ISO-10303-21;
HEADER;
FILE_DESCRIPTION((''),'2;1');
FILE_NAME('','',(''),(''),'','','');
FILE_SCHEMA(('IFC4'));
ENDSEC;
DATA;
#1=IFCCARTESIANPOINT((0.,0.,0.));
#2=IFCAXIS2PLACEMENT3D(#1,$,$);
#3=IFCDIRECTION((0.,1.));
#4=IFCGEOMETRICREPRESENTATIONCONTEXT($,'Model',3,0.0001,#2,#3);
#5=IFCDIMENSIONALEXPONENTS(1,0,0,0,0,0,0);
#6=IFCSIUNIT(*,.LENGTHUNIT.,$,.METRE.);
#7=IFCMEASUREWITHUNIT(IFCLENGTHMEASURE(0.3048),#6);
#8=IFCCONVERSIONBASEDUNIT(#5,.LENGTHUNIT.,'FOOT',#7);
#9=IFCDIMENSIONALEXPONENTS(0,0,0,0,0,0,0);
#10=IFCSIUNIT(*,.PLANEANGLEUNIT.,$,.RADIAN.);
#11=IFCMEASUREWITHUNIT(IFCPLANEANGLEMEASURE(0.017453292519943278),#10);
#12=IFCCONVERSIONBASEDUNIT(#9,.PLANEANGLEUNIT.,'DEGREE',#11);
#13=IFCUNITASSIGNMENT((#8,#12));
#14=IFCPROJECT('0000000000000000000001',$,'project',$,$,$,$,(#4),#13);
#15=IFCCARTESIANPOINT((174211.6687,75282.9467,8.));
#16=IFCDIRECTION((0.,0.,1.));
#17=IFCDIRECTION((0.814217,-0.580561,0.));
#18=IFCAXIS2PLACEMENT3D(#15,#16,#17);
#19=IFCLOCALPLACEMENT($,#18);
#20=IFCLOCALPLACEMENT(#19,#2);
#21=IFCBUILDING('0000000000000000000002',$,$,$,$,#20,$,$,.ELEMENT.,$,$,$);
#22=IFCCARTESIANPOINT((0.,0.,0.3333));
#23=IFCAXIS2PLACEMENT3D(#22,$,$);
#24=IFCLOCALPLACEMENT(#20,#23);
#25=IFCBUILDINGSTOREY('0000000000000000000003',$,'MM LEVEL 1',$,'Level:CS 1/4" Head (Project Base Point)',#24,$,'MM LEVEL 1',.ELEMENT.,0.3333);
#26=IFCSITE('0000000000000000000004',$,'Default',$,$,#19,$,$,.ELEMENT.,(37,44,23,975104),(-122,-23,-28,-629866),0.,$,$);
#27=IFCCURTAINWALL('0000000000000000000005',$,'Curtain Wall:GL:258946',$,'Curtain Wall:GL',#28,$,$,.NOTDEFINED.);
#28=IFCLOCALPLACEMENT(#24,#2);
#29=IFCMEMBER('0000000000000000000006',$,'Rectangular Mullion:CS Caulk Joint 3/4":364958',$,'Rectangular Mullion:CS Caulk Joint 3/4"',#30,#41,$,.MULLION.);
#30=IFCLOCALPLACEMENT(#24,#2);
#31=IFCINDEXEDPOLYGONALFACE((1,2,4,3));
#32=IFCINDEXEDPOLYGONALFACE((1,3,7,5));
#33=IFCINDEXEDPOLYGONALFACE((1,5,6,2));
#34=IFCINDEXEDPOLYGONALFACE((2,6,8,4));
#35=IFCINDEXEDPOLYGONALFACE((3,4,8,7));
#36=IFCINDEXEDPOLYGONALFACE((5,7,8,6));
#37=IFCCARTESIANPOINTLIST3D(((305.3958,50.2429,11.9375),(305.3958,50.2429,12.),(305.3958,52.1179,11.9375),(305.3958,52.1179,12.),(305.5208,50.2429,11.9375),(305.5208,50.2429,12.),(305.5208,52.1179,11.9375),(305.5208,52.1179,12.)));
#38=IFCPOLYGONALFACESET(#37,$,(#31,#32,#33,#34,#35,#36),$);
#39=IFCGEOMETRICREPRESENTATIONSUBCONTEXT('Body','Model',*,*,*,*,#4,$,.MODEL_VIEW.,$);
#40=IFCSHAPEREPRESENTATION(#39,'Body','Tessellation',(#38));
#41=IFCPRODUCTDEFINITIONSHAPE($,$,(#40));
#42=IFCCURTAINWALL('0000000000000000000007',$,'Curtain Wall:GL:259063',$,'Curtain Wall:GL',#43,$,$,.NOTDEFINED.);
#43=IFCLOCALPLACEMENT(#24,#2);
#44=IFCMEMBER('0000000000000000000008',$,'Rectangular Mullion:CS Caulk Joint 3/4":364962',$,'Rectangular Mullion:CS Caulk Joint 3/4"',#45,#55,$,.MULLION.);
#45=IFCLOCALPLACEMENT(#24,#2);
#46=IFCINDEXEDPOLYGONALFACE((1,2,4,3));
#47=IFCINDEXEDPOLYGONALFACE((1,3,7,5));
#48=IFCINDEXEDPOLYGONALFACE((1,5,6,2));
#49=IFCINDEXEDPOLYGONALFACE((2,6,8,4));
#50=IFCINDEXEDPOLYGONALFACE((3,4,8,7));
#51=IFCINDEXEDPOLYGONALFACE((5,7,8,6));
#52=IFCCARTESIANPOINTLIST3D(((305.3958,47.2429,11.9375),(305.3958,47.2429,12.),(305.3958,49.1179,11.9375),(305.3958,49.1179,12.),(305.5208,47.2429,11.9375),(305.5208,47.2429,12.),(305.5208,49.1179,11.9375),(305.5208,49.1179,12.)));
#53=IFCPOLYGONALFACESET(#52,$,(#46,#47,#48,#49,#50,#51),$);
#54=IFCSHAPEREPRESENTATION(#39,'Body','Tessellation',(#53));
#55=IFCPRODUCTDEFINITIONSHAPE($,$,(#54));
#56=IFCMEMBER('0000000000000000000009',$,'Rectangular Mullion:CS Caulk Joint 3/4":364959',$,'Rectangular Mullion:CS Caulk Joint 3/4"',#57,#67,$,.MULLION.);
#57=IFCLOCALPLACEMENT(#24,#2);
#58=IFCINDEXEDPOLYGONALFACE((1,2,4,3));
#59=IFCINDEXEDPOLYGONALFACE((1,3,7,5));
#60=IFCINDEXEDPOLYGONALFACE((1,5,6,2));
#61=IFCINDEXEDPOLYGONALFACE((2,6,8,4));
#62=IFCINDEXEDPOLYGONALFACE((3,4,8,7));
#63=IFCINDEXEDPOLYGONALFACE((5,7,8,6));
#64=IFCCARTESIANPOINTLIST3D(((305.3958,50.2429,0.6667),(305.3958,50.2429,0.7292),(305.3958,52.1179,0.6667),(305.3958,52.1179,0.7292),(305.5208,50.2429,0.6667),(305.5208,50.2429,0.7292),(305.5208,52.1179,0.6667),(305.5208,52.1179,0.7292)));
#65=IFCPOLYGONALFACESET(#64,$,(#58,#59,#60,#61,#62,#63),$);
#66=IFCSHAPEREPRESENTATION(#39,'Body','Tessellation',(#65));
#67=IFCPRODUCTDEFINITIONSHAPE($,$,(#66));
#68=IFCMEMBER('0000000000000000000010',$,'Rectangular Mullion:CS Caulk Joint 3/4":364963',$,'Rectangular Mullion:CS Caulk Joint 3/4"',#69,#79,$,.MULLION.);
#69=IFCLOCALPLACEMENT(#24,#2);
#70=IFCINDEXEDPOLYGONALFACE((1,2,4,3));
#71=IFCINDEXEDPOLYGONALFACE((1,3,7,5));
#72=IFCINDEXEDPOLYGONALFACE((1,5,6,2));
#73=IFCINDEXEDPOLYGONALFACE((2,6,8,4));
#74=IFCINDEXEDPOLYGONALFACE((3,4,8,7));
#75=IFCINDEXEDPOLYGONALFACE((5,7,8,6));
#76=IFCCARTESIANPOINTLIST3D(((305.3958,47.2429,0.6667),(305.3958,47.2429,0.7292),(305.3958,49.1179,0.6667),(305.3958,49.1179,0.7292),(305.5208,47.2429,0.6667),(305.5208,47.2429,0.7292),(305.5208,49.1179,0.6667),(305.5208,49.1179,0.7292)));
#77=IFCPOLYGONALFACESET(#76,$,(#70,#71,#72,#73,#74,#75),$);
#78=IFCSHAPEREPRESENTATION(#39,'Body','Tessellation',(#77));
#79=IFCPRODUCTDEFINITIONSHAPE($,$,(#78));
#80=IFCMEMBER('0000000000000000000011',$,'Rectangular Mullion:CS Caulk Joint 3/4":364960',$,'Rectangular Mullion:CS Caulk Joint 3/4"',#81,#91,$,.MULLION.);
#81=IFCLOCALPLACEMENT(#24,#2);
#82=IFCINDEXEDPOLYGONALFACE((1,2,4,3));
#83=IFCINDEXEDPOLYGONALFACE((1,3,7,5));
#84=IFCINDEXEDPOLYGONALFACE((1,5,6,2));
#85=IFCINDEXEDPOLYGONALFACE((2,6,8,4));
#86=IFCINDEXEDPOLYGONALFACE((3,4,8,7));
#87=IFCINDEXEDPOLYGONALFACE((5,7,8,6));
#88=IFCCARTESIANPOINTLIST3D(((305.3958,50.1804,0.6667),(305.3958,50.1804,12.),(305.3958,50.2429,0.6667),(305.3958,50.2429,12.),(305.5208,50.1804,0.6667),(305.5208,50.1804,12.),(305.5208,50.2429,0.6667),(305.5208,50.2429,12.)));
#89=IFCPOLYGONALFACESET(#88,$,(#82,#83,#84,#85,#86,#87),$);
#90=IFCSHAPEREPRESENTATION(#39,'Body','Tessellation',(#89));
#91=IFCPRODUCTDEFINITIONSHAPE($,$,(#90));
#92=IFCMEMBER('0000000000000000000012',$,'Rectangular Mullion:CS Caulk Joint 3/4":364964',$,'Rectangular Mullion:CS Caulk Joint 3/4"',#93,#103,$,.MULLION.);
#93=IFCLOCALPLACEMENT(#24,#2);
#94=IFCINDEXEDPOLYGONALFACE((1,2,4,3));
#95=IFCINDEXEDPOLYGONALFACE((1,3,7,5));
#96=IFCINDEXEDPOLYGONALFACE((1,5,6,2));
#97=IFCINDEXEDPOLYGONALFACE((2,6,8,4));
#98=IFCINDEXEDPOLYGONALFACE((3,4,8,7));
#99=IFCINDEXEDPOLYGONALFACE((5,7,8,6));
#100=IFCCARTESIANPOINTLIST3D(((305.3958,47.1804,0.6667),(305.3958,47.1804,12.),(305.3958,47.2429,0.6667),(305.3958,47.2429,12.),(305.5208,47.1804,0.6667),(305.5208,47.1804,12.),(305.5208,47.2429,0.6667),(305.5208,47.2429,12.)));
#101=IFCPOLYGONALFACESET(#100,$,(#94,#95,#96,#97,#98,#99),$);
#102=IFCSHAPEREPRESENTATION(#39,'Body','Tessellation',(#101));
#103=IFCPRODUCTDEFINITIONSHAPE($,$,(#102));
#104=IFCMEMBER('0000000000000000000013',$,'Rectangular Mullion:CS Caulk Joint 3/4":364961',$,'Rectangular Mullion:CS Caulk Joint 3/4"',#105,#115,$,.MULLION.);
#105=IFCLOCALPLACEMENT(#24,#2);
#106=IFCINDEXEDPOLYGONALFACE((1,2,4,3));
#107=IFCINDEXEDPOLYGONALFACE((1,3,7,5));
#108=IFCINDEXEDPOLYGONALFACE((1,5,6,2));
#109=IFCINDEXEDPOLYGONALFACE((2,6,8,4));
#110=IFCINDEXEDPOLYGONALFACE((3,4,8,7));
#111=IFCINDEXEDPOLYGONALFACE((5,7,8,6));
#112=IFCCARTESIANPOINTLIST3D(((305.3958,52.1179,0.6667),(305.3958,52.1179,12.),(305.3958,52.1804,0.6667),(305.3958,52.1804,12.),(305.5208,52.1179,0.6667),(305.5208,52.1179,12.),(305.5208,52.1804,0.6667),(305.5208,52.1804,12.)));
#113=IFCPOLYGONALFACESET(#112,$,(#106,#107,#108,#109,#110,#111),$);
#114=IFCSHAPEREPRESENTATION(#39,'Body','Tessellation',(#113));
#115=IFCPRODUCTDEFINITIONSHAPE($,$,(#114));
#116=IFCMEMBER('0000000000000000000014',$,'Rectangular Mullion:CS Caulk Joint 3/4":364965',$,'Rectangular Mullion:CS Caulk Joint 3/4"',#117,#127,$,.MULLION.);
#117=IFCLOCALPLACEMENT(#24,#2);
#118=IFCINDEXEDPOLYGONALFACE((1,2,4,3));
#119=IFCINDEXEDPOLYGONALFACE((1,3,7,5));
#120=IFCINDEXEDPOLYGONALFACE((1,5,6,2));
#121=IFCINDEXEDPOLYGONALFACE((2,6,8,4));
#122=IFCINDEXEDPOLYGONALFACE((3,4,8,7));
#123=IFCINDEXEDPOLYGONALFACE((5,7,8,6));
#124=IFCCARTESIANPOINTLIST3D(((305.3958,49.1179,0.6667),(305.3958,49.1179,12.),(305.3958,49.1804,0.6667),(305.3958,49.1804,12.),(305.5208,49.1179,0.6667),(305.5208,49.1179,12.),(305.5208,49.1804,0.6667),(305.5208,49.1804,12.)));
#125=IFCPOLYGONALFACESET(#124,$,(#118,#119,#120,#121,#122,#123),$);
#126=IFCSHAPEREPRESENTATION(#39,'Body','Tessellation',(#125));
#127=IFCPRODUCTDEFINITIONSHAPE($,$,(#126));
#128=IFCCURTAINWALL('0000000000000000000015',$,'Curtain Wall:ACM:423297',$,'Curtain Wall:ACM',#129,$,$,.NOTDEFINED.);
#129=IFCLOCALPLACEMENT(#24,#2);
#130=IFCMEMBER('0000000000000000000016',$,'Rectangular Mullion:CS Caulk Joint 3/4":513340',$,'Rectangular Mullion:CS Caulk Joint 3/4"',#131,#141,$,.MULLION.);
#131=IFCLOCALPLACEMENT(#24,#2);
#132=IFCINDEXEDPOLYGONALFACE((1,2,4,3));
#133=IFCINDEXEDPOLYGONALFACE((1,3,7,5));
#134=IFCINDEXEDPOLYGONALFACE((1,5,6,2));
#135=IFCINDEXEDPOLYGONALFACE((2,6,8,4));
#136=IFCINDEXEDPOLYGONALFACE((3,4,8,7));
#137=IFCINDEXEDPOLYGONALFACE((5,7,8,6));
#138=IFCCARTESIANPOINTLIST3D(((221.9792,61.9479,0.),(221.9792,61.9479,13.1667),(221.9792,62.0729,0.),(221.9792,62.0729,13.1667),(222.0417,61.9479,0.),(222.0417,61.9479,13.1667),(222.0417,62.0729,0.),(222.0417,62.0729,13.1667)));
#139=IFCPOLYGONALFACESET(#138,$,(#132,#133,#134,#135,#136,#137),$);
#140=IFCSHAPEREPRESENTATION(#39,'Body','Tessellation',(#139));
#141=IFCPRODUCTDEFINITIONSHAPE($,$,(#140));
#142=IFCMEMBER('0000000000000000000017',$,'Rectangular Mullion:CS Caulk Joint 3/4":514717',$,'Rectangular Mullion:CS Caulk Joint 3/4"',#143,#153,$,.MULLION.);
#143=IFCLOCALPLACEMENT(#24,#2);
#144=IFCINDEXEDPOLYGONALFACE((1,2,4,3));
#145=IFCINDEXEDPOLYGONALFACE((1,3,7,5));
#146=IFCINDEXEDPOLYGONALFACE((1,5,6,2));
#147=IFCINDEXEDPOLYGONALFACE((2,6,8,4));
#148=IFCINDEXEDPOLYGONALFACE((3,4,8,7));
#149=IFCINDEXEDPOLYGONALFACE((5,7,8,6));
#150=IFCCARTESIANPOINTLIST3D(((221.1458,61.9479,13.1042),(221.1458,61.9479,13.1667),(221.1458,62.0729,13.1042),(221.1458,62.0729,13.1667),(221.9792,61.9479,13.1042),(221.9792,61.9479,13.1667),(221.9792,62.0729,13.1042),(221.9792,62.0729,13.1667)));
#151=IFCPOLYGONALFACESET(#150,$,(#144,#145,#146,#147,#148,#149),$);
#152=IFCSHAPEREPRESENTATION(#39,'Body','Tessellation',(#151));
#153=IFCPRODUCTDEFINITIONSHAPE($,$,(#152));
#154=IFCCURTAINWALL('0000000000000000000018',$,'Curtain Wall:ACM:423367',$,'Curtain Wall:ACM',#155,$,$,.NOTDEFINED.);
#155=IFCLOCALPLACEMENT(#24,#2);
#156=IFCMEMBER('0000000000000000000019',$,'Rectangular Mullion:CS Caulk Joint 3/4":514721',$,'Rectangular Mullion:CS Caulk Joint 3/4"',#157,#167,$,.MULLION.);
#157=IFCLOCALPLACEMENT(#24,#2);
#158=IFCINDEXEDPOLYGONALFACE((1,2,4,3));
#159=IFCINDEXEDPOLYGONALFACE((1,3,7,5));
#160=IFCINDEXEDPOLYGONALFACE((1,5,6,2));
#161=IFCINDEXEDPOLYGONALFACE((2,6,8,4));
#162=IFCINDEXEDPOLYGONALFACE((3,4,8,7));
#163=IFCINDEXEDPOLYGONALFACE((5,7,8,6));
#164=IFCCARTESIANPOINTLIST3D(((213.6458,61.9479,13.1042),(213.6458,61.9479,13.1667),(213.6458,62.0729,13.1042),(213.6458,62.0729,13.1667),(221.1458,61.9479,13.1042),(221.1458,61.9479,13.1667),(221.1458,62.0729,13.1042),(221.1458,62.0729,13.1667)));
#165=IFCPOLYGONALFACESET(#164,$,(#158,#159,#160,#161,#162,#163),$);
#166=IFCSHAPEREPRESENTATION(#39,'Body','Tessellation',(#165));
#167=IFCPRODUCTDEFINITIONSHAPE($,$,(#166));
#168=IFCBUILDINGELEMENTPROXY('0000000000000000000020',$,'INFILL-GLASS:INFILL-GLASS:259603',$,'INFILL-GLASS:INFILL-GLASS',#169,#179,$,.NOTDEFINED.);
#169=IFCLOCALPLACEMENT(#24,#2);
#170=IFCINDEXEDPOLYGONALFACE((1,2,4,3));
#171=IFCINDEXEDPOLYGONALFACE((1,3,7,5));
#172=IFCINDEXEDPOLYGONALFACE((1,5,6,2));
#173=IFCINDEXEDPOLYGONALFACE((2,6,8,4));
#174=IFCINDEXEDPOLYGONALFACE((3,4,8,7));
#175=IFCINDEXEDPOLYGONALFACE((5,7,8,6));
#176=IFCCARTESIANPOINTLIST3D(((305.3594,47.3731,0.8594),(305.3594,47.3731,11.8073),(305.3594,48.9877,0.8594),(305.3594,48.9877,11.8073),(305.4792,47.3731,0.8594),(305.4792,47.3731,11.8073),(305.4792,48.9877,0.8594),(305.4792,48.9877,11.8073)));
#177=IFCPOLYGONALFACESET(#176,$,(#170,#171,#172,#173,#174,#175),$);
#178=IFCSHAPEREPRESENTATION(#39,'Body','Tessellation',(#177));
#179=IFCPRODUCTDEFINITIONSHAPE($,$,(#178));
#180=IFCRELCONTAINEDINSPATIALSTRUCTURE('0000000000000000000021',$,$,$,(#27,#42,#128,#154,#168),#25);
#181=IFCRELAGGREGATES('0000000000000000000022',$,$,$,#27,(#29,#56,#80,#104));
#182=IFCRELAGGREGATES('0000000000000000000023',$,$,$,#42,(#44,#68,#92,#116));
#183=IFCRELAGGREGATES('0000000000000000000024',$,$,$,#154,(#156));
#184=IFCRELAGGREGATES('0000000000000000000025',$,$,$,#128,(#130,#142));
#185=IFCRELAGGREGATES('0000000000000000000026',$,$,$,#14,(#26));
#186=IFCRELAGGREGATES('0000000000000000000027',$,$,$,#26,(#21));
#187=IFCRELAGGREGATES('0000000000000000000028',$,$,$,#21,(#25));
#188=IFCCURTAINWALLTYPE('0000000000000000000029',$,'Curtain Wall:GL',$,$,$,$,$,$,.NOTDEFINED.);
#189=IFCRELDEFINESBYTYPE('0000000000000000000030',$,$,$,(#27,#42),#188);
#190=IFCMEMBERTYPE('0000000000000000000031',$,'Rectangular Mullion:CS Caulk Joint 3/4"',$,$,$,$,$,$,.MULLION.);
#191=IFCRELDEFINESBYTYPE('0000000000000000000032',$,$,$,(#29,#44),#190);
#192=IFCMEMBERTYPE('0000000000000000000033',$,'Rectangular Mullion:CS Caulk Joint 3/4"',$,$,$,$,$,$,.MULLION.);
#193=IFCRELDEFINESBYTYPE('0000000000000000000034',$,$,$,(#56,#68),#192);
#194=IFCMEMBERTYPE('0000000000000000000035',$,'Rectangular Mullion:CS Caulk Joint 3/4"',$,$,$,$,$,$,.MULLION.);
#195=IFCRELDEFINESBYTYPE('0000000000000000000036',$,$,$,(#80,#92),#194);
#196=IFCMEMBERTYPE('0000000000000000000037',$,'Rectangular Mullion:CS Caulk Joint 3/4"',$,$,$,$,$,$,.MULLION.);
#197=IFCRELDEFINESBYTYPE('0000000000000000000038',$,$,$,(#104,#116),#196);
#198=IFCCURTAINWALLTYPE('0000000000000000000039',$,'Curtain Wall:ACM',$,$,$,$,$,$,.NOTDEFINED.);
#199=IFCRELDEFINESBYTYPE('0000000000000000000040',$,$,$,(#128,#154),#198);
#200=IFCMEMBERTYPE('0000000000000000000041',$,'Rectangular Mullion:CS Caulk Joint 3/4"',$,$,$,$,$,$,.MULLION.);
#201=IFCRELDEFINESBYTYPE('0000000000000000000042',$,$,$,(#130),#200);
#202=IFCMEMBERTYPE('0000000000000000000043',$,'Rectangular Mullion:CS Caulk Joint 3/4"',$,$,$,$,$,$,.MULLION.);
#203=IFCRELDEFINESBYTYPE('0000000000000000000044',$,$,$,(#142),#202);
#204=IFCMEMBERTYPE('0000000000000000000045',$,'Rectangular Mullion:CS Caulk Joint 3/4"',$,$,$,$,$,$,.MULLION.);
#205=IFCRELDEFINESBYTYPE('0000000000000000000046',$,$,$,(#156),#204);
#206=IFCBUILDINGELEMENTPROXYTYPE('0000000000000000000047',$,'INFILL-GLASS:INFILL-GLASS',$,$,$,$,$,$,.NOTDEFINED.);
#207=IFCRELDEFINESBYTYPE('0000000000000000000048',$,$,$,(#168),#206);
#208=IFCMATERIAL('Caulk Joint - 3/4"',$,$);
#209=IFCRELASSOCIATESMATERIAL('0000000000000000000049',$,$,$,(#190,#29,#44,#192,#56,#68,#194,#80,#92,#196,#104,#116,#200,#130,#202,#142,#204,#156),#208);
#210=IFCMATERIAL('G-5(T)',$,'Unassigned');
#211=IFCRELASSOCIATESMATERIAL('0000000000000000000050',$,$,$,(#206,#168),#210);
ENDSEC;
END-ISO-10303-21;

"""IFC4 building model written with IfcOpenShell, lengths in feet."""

from ifc_helpers import new_model, entity, si_unit, converted_unit, direction, frame, origin, place, context, subcontext, project, spatial, indexed_curve, outline, extrude, source, transform, mapped, material, type_object, type_shapes, element, aggregate, save


model = new_model("IFC4")

# Units and contexts
model_context = context("Model", 3, precision=0.0001, world=origin(), true_north=direction((0.0, 1.0)))
body_context = subcontext(model_context, "Body", "Model", "MODEL_VIEW")
ifc_project = project(units=[converted_unit("LENGTHUNIT", "FOOT", entity("IfcLengthMeasure", 0.3048), si_unit("LENGTHUNIT", "METRE"), dimensions=[1, 0, 0, 0, 0, 0, 0]), converted_unit("PLANEANGLEUNIT", "DEGREE", entity("IfcPlaneAngleMeasure", 0.017453292519943278), si_unit("PLANEANGLEUNIT", "RADIAN"), dimensions=[0, 0, 0, 0, 0, 0, 0])], contexts=[model_context])

# Site, building, storey
site_placement = place(None, frame((174211.6687, 75282.9467, 8.0), z_axis=(0.0, 0.0, 1.0), x_axis=(0.814217, -0.580561, 0.0)))
site = spatial("IfcSite", under=ifc_project, at=site_placement, Name="Default", CompositionType="ELEMENT", RefLatitude=(37, 44, 23, 975104), RefLongitude=(-122, -23, -28, -629866), RefElevation=0.0)
building_placement = place(site_placement, origin())
building = spatial("IfcBuilding", under=site, at=building_placement, CompositionType="ELEMENT")
storey_placement = place(building_placement, frame((0.0, 0.0, 0.3333)))
storey = spatial("IfcBuildingStorey", under=building, at=storey_placement, Name="MM LEVEL 1", ObjectType="Level:CS 1/4\" Head (Project Base Point)", LongName="MM LEVEL 1", CompositionType="ELEMENT", Elevation=0.3333)

# Curtain walls, members
curtain_wall_type_1 = type_object("IfcCurtainWallType", Name="Curtain Wall:GL", PredefinedType="NOTDEFINED")
curtain_wall_1_placement = place(storey_placement, frame((0.0, 0.0, -0.3333)))
curtain_wall_1 = element("IfcCurtainWall", 1, at=curtain_wall_1_placement, inside=storey, type_object=curtain_wall_type_1, Name="Curtain Wall:GL:258946", ObjectType="Curtain Wall:GL", PredefinedType="NOTDEFINED")
ifc_material_1 = material(Name="Caulk Joint - 3/4\"")
member_type_1 = type_object("IfcMemberType", Name="Rectangular Mullion:CS Caulk Joint 3/4\"", PredefinedType="MULLION", material=ifc_material_1)
shared_shape_1 = source(origin(), body_context, "Body", "SweptSolid", [
    extrude(outline(indexed_curve([(-0.0625, -0.0312), (0.0625, -0.0312), (0.0625, 0.0312), (-0.0625, 0.0312), (-0.0625, -0.0312)], self_intersect=False)), frame((-0.0312, 0.0625, -1.875), z_axis=(0.0, 0.0, 1.0), x_axis=(0.0, -1.0, 0.0)), (0.0, 0.0, 1.0), 1.875),
])
type_shapes(member_type_1, [shared_shape_1])
member_1_placement = place(curtain_wall_1_placement, frame((305.5208, 50.2429, 12.3333), z_axis=(0.0, -1.0, 0.0), x_axis=(0.0, 0.0, 1.0)))
member_1 = element("IfcMember", 2, at=member_1_placement, type_object=member_type_1, material=ifc_material_1, Name="Rectangular Mullion:CS Caulk Joint 3/4\":364958", ObjectType="Rectangular Mullion:CS Caulk Joint 3/4\"", PredefinedType="MULLION", context=body_context, shape_type="MappedRepresentation", body=[
    mapped(shared_shape_1, transform((0.0, 0.0, 0.0), scale=1.0)),
])
curtain_wall_2_placement = place(storey_placement, frame((0.0, 0.0, -0.3333)))
curtain_wall_2 = element("IfcCurtainWall", 3, at=curtain_wall_2_placement, inside=storey, type_object=curtain_wall_type_1, Name="Curtain Wall:GL:259063", ObjectType="Curtain Wall:GL", PredefinedType="NOTDEFINED")
member_2_placement = place(curtain_wall_2_placement, frame((305.5208, 47.2429, 12.3333), z_axis=(0.0, -1.0, 0.0), x_axis=(0.0, 0.0, 1.0)))
member_2 = element("IfcMember", 4, at=member_2_placement, type_object=member_type_1, material=ifc_material_1, Name="Rectangular Mullion:CS Caulk Joint 3/4\":364962", ObjectType="Rectangular Mullion:CS Caulk Joint 3/4\"", PredefinedType="MULLION", context=body_context, shape_type="MappedRepresentation", body=[
    mapped(shared_shape_1, transform((0.0, 0.0, 0.0), scale=1.0)),
])

# Members
member_type_2 = type_object("IfcMemberType", Name="Rectangular Mullion:CS Caulk Joint 3/4\"", PredefinedType="MULLION", material=ifc_material_1)
shared_shape_2 = source(origin(), body_context, "Body", "SweptSolid", [
    extrude(outline(indexed_curve([(-0.0312, -0.0625), (0.0312, -0.0625), (0.0312, 0.0625), (-0.0312, 0.0625), (-0.0312, -0.0625)], self_intersect=False)), frame((-0.0312, 0.0625, -1.875), z_axis=(0.0, 0.0, 1.0), x_axis=(-1.0, 0.0, 0.0)), (0.0, 0.0, 1.0), 1.875),
])
type_shapes(member_type_2, [shared_shape_2])
member_3_placement = place(curtain_wall_1_placement, frame((305.5208, 52.1179, 1.0), z_axis=(0.0, 1.0, 0.0), x_axis=(0.0, 0.0, -1.0)))
member_3 = element("IfcMember", 5, at=member_3_placement, type_object=member_type_2, material=ifc_material_1, Name="Rectangular Mullion:CS Caulk Joint 3/4\":364959", ObjectType="Rectangular Mullion:CS Caulk Joint 3/4\"", PredefinedType="MULLION", context=body_context, shape_type="MappedRepresentation", body=[
    mapped(shared_shape_2, transform((0.0, 0.0, 0.0), scale=1.0)),
])
member_4_placement = place(curtain_wall_2_placement, frame((305.5208, 49.1179, 1.0), z_axis=(0.0, 1.0, 0.0), x_axis=(0.0, 0.0, -1.0)))
member_4 = element("IfcMember", 6, at=member_4_placement, type_object=member_type_2, material=ifc_material_1, Name="Rectangular Mullion:CS Caulk Joint 3/4\":364963", ObjectType="Rectangular Mullion:CS Caulk Joint 3/4\"", PredefinedType="MULLION", context=body_context, shape_type="MappedRepresentation", body=[
    mapped(shared_shape_2, transform((0.0, 0.0, 0.0), scale=1.0)),
])
member_type_3 = type_object("IfcMemberType", Name="Rectangular Mullion:CS Caulk Joint 3/4\"", PredefinedType="MULLION", material=ifc_material_1)
shared_shape_3 = source(origin(), body_context, "Body", "SweptSolid", [
    extrude(outline(indexed_curve([(-0.0625, -0.0312), (0.0625, -0.0312), (0.0625, 0.0312), (-0.0625, 0.0312), (-0.0625, -0.0312)], self_intersect=False)), frame((-0.0312, 0.0625, -11.3333), z_axis=(0.0, 0.0, 1.0), x_axis=(0.0, -1.0, 0.0)), (0.0, 0.0, 1.0), 11.3333),
])
type_shapes(member_type_3, [shared_shape_3])
member_5_placement = place(curtain_wall_1_placement, frame((305.5208, 50.1804, 1.0), z_axis=(0.0, 0.0, -1.0), x_axis=(0.0, -1.0, 0.0)))
member_5 = element("IfcMember", 7, at=member_5_placement, type_object=member_type_3, material=ifc_material_1, Name="Rectangular Mullion:CS Caulk Joint 3/4\":364960", ObjectType="Rectangular Mullion:CS Caulk Joint 3/4\"", PredefinedType="MULLION", context=body_context, shape_type="MappedRepresentation", body=[
    mapped(shared_shape_3, transform((0.0, 0.0, 0.0), scale=1.0)),
])
member_6_placement = place(curtain_wall_2_placement, frame((305.5208, 47.1804, 1.0), z_axis=(0.0, 0.0, -1.0), x_axis=(0.0, -1.0, 0.0)))
member_6 = element("IfcMember", 8, at=member_6_placement, type_object=member_type_3, material=ifc_material_1, Name="Rectangular Mullion:CS Caulk Joint 3/4\":364964", ObjectType="Rectangular Mullion:CS Caulk Joint 3/4\"", PredefinedType="MULLION", context=body_context, shape_type="MappedRepresentation", body=[
    mapped(shared_shape_3, transform((0.0, 0.0, 0.0), scale=1.0)),
])
member_type_4 = type_object("IfcMemberType", Name="Rectangular Mullion:CS Caulk Joint 3/4\"", PredefinedType="MULLION", material=ifc_material_1)
shared_shape_4 = source(origin(), body_context, "Body", "SweptSolid", [
    extrude(outline(indexed_curve([(-0.0312, -0.0625), (0.0312, -0.0625), (0.0312, 0.0625), (-0.0312, 0.0625), (-0.0312, -0.0625)], self_intersect=False)), frame((-0.0312, 0.0625, -11.3333), z_axis=(0.0, 0.0, 1.0), x_axis=(-1.0, 0.0, 0.0)), (0.0, 0.0, 1.0), 11.3333),
])
type_shapes(member_type_4, [shared_shape_4])
member_7_placement = place(curtain_wall_1_placement, frame((305.5208, 52.1804, 12.3333), z_axis=(0.0, 0.0, 1.0), x_axis=(0.0, 1.0, 0.0)))
member_7 = element("IfcMember", 9, at=member_7_placement, type_object=member_type_4, material=ifc_material_1, Name="Rectangular Mullion:CS Caulk Joint 3/4\":364961", ObjectType="Rectangular Mullion:CS Caulk Joint 3/4\"", PredefinedType="MULLION", context=body_context, shape_type="MappedRepresentation", body=[
    mapped(shared_shape_4, transform((0.0, 0.0, 0.0), scale=1.0)),
])
aggregate(curtain_wall_1, [member_1, member_3, member_5, member_7])
member_8_placement = place(curtain_wall_2_placement, frame((305.5208, 49.1804, 12.3333), z_axis=(0.0, 0.0, 1.0), x_axis=(0.0, 1.0, 0.0)))
member_8 = element("IfcMember", 10, at=member_8_placement, type_object=member_type_4, material=ifc_material_1, Name="Rectangular Mullion:CS Caulk Joint 3/4\":364965", ObjectType="Rectangular Mullion:CS Caulk Joint 3/4\"", PredefinedType="MULLION", context=body_context, shape_type="MappedRepresentation", body=[
    mapped(shared_shape_4, transform((0.0, 0.0, 0.0), scale=1.0)),
])
aggregate(curtain_wall_2, [member_2, member_4, member_6, member_8])

# Curtain wall, members
curtain_wall_type_2 = type_object("IfcCurtainWallType", Name="Curtain Wall:ACM", PredefinedType="NOTDEFINED")
curtain_wall_3_placement = place(storey_placement, frame((0.0, 0.0, -0.3333)))
curtain_wall_3 = element("IfcCurtainWall", 11, at=curtain_wall_3_placement, inside=storey, type_object=curtain_wall_type_2, Name="Curtain Wall:ACM:423297", ObjectType="Curtain Wall:ACM", PredefinedType="NOTDEFINED")
member_type_5 = type_object("IfcMemberType", Name="Rectangular Mullion:CS Caulk Joint 3/4\"", PredefinedType="MULLION", material=ifc_material_1)
shared_shape_5 = source(origin(), body_context, "Body", "SweptSolid", [
    extrude(outline(indexed_curve([(-0.0625, -0.0312), (0.0625, -0.0312), (0.0625, 0.0312), (-0.0625, 0.0312), (-0.0625, -0.0312)], self_intersect=False)), frame((-0.0312, 0.0625, -13.1667), z_axis=(0.0, 0.0, 1.0), x_axis=(0.0, -1.0, 0.0)), (0.0, 0.0, 1.0), 13.1667),
])
type_shapes(member_type_5, [shared_shape_5])
member_9_placement = place(curtain_wall_3_placement, frame((222.0417, 62.0729, 0.3333), z_axis=(0.0, 0.0, -1.0), x_axis=(1.0, 0.0, 0.0)))
member_9 = element("IfcMember", 12, at=member_9_placement, type_object=member_type_5, material=ifc_material_1, Name="Rectangular Mullion:CS Caulk Joint 3/4\":513340", ObjectType="Rectangular Mullion:CS Caulk Joint 3/4\"", PredefinedType="MULLION", context=body_context, shape_type="MappedRepresentation", body=[
    mapped(shared_shape_5, transform((0.0, 0.0, 0.0), scale=1.0)),
])
member_type_6 = type_object("IfcMemberType", Name="Rectangular Mullion:CS Caulk Joint 3/4\"", PredefinedType="MULLION", material=ifc_material_1)
shared_shape_6 = source(origin(), body_context, "Body", "SweptSolid", [
    extrude(outline(indexed_curve([(-0.4167, -0.0625), (0.4167, -0.0625), (0.4167, 0.0625), (-0.4167, 0.0625), (-0.4167, -0.0625)], self_intersect=False)), frame((-0.0625, 0.0625, -0.4167), z_axis=(1.0, 0.0, 0.0), x_axis=(0.0, 0.0, -1.0)), (0.0, 0.0, 1.0), 0.0625),
])
type_shapes(member_type_6, [shared_shape_6])
member_10_placement = place(curtain_wall_3_placement, frame((221.9792, 62.0729, 13.5), z_axis=(1.0, 0.0, 0.0), x_axis=(0.0, 0.0, 1.0)))
member_10 = element("IfcMember", 13, at=member_10_placement, type_object=member_type_6, material=ifc_material_1, Name="Rectangular Mullion:CS Caulk Joint 3/4\":514717", ObjectType="Rectangular Mullion:CS Caulk Joint 3/4\"", PredefinedType="MULLION", context=body_context, shape_type="MappedRepresentation", body=[
    mapped(shared_shape_6, transform((0.0, 0.0, 0.0), scale=1.0)),
])

# Curtain wall, member
curtain_wall_4_placement = place(storey_placement, frame((0.0, 0.0, -0.3333)))
curtain_wall_4 = element("IfcCurtainWall", 14, at=curtain_wall_4_placement, inside=storey, type_object=curtain_wall_type_2, Name="Curtain Wall:ACM:423367", ObjectType="Curtain Wall:ACM", PredefinedType="NOTDEFINED")
member_type_7 = type_object("IfcMemberType", Name="Rectangular Mullion:CS Caulk Joint 3/4\"", PredefinedType="MULLION", material=ifc_material_1)
shared_shape_7 = source(origin(), body_context, "Body", "SweptSolid", [
    extrude(outline(indexed_curve([(-3.75, -0.0625), (3.75, -0.0625), (3.75, 0.0625), (-3.75, 0.0625), (-3.75, -0.0625)], self_intersect=False)), frame((-0.0625, 0.0625, -3.75), z_axis=(1.0, 0.0, 0.0), x_axis=(0.0, 0.0, -1.0)), (0.0, 0.0, 1.0), 0.0625),
])
type_shapes(member_type_7, [shared_shape_7])
member_11_placement = place(curtain_wall_4_placement, frame((221.1458, 62.0729, 13.5), z_axis=(1.0, 0.0, 0.0), x_axis=(0.0, 0.0, 1.0)))
member_11 = element("IfcMember", 15, at=member_11_placement, type_object=member_type_7, material=ifc_material_1, Name="Rectangular Mullion:CS Caulk Joint 3/4\":514721", ObjectType="Rectangular Mullion:CS Caulk Joint 3/4\"", PredefinedType="MULLION", context=body_context, shape_type="MappedRepresentation", body=[
    mapped(shared_shape_7, transform((0.0, 0.0, 0.0), scale=1.0)),
])
aggregate(curtain_wall_4, [member_11])

aggregate(curtain_wall_3, [member_9, member_10])

# Building element proxy
ifc_material_2 = material(Name="G-5(T)", Category="Unassigned")
building_element_proxy_type_1 = type_object("IfcBuildingElementProxyType", Name="INFILL-GLASS:INFILL-GLASS", PredefinedType="NOTDEFINED", material=ifc_material_2)
shared_shape_8 = source(origin(), body_context, "Body", "SweptSolid", [
    extrude(outline(indexed_curve([(-0.0599, -0.8073), (0.0599, -0.8073), (0.0599, 0.8073), (-0.0599, 0.8073), (-0.0599, -0.8073)], self_intersect=False)), frame((0.0, 0.1016, 0.1302), z_axis=(0.0, 0.0, 1.0), x_axis=(0.0, 1.0, 0.0)), (0.0, 0.0, 1.0), 10.9479),
])
type_shapes(building_element_proxy_type_1, [shared_shape_8])
proxy_1_placement = place(storey_placement, frame((305.5208, 48.1804, 0.7292), z_axis=(0.0, 0.0, 1.0), x_axis=(0.0, 1.0, 0.0)))
element("IfcBuildingElementProxy", 16, at=proxy_1_placement, inside=storey, type_object=building_element_proxy_type_1, material=ifc_material_2, Name="INFILL-GLASS:INFILL-GLASS:259603", ObjectType="INFILL-GLASS:INFILL-GLASS", PredefinedType="NOTDEFINED", context=body_context, shape_type="MappedRepresentation", body=[
    mapped(shared_shape_8, transform((0.0, 0.0, 0.0), scale=1.0)),
])

save(model, "model.ifc")
